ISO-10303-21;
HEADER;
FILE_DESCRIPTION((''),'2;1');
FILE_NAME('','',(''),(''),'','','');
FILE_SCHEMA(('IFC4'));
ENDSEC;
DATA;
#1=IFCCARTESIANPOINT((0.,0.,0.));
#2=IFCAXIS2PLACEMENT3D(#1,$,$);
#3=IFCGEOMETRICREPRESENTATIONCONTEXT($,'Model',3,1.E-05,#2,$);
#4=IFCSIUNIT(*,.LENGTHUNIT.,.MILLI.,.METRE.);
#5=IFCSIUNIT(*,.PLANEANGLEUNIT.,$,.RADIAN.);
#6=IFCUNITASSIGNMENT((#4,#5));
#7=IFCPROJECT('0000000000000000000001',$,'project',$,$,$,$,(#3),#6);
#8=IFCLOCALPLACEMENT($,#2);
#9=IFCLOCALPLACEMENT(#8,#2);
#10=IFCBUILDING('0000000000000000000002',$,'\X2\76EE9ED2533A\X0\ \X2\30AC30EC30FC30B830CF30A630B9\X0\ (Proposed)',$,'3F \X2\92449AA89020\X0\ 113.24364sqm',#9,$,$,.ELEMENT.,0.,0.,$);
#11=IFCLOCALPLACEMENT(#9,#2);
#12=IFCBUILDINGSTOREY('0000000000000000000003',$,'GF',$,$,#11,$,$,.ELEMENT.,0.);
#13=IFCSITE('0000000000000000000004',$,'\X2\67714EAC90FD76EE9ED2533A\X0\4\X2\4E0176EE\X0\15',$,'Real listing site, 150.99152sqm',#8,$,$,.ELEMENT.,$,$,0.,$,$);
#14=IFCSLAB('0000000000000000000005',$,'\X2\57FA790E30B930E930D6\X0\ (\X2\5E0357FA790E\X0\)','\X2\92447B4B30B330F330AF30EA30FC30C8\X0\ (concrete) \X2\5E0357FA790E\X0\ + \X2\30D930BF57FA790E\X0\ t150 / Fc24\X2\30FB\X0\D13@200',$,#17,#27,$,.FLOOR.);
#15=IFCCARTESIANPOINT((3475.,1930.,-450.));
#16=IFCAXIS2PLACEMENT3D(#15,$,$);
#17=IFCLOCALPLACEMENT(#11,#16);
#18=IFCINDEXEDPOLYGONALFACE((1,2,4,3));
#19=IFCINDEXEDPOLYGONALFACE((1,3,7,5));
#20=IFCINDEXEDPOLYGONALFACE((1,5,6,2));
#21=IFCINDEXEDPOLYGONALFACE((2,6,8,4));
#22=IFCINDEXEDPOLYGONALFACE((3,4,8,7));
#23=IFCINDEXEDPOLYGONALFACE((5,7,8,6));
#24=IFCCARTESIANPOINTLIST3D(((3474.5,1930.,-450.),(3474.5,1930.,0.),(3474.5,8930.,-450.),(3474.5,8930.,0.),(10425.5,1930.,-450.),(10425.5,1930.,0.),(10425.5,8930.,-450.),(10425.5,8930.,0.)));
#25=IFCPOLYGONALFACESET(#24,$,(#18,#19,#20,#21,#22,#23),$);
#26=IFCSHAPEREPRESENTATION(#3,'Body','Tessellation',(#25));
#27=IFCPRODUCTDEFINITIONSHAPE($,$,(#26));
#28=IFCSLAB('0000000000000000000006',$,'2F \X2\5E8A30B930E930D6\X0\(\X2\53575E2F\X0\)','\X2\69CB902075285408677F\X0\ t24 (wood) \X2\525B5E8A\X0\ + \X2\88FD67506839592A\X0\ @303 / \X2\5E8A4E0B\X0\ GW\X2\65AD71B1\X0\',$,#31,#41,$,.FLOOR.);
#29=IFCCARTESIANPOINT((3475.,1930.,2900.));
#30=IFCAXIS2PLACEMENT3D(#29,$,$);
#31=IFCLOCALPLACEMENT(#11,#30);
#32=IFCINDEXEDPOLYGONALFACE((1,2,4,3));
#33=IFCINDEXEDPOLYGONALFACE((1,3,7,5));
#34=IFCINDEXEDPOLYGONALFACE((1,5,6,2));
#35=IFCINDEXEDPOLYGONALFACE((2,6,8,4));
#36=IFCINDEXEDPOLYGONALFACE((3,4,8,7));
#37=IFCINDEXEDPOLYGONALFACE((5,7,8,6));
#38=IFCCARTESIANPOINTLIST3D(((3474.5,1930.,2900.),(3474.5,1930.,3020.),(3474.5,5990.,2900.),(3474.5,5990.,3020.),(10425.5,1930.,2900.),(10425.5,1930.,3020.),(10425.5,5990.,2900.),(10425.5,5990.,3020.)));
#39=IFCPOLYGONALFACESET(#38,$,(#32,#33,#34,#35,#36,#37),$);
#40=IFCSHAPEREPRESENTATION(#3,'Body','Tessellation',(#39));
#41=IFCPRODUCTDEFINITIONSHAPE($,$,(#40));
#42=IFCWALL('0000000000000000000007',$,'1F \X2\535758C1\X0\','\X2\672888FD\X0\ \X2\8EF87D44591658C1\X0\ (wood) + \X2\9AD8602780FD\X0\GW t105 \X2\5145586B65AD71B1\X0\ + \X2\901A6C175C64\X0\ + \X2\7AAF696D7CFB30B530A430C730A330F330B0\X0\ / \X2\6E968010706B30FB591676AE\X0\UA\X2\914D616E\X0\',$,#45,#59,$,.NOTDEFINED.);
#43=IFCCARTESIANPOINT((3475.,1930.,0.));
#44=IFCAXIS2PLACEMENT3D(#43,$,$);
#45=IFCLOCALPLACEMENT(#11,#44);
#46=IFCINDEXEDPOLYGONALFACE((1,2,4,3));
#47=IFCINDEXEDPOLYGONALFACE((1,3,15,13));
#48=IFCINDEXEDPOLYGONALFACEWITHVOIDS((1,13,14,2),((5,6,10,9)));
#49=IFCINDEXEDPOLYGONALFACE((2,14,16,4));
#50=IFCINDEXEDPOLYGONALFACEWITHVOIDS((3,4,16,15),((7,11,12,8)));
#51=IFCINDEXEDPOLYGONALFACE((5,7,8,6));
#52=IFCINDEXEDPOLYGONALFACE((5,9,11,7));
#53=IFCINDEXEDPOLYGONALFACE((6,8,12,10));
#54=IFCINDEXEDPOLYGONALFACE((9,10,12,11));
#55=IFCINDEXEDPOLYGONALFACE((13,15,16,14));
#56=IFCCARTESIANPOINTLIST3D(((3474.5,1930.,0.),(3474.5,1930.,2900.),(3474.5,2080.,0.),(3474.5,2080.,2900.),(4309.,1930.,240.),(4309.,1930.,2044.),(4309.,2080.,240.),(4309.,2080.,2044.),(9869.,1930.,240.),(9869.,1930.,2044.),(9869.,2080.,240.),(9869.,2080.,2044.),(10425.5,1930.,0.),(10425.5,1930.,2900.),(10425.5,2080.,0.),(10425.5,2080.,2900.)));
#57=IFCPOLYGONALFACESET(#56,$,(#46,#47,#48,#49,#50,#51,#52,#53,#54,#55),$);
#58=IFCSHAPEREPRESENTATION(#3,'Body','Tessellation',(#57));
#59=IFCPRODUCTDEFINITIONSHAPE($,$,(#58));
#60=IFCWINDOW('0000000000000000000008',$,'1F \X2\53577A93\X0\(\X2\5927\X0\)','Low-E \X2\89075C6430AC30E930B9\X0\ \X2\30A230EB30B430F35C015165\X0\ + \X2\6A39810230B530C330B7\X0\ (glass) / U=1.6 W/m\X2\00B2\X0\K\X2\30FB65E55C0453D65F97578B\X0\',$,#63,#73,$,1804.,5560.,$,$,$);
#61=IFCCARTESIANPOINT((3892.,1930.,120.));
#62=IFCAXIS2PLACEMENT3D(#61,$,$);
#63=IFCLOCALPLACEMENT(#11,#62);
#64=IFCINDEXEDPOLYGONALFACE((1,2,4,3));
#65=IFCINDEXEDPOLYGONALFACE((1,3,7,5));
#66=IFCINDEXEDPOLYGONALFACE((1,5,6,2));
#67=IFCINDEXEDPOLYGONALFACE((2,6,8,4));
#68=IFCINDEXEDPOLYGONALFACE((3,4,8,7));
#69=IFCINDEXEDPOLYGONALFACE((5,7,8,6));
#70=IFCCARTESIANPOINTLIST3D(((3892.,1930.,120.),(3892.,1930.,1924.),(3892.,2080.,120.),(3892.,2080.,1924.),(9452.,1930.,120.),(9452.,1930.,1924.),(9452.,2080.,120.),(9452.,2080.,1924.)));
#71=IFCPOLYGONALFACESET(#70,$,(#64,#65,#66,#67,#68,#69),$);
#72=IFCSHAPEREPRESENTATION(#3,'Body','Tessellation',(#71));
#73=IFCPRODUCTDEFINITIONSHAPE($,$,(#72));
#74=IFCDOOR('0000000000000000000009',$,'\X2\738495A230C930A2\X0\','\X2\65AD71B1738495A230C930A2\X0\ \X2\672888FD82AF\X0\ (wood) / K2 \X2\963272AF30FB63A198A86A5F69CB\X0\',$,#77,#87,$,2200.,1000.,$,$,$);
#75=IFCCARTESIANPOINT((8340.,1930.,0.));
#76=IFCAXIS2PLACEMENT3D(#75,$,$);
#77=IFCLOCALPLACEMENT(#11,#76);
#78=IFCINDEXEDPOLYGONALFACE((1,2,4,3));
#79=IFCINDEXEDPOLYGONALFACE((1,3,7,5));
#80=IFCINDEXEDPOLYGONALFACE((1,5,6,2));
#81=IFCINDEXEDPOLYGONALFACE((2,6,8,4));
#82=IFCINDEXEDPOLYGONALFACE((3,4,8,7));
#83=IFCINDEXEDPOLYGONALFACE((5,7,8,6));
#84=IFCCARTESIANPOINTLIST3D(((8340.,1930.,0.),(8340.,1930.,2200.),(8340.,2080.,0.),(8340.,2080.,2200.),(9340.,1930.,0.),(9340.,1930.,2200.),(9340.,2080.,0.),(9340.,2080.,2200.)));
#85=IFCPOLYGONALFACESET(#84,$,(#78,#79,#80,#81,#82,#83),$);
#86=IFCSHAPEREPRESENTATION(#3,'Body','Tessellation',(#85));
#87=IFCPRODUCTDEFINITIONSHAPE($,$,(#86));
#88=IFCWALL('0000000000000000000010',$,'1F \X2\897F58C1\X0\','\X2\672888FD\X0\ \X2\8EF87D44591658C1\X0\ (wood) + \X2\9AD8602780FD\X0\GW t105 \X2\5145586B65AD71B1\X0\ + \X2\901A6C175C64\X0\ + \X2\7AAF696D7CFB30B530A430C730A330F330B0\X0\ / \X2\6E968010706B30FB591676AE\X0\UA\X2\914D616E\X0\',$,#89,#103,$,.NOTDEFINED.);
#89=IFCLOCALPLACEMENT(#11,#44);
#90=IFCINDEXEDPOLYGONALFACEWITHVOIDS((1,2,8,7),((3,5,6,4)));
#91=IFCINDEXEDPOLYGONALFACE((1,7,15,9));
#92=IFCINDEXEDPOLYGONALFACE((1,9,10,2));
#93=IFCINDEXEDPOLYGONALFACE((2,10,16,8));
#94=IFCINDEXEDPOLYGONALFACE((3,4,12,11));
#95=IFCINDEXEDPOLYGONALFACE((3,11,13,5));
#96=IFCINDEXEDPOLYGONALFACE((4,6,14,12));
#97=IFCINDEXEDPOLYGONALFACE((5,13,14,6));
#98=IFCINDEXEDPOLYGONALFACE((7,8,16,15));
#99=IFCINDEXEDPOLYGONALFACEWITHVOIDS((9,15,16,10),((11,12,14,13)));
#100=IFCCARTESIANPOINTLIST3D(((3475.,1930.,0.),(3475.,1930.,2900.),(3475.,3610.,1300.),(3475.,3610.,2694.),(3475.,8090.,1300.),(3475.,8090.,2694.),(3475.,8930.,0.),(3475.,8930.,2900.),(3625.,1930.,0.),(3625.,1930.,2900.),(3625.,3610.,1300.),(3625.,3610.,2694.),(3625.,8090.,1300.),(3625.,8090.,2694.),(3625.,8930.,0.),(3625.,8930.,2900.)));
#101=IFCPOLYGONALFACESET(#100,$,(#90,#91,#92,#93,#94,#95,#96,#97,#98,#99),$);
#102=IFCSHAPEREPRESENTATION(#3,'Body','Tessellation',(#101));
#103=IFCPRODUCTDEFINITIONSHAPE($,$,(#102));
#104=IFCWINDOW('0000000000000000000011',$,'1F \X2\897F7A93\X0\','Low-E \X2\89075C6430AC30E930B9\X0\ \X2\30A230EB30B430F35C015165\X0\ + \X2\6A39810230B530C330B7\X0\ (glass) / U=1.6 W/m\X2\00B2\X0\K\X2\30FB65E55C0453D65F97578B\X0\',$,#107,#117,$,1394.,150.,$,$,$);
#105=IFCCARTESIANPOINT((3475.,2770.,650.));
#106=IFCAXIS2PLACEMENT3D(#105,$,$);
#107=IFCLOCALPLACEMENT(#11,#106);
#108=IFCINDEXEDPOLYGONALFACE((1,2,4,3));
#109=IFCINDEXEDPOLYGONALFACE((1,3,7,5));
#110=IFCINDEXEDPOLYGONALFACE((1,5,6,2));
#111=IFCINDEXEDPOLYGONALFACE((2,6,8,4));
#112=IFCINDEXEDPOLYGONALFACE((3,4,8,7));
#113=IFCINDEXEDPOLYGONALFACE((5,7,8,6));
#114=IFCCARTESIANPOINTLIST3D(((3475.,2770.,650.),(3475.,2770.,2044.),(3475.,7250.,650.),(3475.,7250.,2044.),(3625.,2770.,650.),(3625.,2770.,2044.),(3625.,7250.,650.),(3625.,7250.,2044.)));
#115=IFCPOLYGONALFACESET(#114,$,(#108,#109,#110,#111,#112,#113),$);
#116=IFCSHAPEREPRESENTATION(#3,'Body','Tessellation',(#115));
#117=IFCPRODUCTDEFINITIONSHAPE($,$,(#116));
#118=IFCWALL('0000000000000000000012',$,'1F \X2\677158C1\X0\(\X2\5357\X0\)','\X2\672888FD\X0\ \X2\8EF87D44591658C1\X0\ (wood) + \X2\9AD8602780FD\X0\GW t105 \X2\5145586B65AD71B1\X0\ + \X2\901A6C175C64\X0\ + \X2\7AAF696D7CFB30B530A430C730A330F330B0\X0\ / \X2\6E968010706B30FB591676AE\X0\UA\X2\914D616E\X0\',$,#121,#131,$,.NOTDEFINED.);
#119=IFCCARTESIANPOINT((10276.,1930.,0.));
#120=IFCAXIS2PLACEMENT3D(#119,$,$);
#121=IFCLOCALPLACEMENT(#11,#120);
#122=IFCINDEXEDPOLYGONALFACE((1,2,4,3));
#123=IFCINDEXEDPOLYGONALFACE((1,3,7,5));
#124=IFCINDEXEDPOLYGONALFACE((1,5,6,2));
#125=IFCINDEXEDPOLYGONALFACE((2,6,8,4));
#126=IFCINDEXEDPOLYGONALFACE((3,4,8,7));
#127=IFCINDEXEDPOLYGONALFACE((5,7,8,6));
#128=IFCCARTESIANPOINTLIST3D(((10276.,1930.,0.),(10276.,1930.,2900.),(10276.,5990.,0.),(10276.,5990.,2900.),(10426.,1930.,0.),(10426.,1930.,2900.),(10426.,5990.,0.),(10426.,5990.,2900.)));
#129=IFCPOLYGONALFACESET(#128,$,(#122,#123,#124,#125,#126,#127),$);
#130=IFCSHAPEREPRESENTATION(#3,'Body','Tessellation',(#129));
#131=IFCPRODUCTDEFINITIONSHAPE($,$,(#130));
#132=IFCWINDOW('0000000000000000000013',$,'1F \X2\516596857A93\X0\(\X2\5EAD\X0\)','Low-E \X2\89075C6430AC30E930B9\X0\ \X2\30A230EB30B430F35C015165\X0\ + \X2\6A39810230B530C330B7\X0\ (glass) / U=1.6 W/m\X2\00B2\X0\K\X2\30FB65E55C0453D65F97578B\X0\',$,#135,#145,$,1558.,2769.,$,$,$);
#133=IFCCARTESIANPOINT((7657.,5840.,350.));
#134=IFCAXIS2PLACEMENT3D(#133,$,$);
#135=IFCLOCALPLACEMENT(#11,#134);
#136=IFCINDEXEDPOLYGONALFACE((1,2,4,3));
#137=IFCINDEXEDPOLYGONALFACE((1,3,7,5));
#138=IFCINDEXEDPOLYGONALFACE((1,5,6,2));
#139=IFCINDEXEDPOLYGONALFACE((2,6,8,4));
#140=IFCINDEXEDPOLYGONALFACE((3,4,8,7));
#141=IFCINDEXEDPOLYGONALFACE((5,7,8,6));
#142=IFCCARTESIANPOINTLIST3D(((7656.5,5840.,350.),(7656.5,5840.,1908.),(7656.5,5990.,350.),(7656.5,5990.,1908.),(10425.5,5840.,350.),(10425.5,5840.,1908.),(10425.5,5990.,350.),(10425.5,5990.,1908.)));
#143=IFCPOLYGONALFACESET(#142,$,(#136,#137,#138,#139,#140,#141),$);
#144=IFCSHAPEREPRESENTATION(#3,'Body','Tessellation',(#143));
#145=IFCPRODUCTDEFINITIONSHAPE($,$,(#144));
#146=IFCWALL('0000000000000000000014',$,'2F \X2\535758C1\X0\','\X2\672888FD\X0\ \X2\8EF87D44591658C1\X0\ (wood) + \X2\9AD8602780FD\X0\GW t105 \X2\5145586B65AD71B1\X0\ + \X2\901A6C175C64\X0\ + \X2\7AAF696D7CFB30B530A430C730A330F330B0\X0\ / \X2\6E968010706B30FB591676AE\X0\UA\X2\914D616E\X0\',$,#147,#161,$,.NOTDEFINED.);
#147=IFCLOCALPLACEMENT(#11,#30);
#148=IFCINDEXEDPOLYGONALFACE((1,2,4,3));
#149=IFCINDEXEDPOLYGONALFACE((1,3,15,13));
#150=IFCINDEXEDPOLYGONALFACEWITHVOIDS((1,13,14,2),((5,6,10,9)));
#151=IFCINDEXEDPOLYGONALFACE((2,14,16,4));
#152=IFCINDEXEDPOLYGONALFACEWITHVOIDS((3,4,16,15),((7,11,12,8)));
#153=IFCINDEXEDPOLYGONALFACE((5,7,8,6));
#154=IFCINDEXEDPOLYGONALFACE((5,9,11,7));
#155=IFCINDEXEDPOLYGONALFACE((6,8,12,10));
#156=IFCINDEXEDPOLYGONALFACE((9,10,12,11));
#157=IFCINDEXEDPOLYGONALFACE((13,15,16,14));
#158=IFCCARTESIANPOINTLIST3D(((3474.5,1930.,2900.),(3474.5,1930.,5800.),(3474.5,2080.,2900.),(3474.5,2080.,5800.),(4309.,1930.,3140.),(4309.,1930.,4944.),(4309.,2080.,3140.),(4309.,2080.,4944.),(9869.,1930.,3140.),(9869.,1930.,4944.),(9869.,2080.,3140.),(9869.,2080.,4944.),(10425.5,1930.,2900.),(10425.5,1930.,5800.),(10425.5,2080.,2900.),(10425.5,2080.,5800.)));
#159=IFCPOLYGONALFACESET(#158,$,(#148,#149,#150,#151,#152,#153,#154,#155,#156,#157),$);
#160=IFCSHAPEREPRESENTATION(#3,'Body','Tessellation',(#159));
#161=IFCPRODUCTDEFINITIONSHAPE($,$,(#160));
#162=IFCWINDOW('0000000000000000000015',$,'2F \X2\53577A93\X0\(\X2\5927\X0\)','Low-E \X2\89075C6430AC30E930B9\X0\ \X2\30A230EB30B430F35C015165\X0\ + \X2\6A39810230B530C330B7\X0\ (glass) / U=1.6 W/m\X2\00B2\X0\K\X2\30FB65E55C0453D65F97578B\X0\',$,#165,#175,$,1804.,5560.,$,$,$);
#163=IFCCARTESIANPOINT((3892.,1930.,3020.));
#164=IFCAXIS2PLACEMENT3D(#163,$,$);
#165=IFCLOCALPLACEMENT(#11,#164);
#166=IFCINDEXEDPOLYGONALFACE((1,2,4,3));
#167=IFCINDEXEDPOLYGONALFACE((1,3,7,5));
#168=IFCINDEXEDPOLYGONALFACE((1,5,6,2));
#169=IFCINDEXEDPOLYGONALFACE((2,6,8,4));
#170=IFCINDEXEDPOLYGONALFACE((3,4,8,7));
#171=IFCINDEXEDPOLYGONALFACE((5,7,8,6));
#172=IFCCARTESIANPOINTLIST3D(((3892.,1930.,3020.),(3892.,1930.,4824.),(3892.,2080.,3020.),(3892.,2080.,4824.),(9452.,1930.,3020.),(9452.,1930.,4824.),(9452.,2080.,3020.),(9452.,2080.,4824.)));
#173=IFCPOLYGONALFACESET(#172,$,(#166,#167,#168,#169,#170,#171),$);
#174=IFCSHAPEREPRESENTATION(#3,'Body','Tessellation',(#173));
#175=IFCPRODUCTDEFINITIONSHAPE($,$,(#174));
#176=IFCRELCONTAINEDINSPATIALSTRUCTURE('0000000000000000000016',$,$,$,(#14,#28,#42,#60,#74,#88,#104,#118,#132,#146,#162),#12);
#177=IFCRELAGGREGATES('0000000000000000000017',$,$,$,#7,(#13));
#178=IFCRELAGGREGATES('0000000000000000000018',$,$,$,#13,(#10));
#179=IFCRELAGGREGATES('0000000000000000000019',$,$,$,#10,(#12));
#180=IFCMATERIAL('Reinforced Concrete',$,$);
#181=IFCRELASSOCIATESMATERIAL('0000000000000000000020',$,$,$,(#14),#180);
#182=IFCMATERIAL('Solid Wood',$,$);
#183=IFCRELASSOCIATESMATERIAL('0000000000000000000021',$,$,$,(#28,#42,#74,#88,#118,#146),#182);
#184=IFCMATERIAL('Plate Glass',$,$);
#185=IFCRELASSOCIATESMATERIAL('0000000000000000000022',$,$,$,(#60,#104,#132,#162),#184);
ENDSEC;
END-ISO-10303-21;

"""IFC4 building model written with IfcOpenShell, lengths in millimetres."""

from ifc_helpers import new_model, si_unit, frame, frame_2d, origin, place, context, project, spatial, rectangle, extrude, material, element, fill, save


model = new_model("IFC4")

# Units and contexts
model_context = context("Model", 3, precision=1e-05, world=origin())
ifc_project = project(units=[si_unit("LENGTHUNIT", "METRE", prefix="MILLI"), si_unit("PLANEANGLEUNIT", "RADIAN")], contexts=[model_context])

# Site, building, storey
site_placement = place(None, origin())
site = spatial("IfcSite", under=ifc_project, at=site_placement, Name="東京都目黒区4丁目15", ObjectType="Real listing site, 150.99152sqm", CompositionType="ELEMENT", RefElevation=0.0)
building_placement = place(site_placement, origin())
building = spatial("IfcBuilding", under=site, at=building_placement, Name="目黒区 ガレージハウス (Proposed)", ObjectType="3F 鉄骨造 113.24364sqm", CompositionType="ELEMENT", ElevationOfRefHeight=0.0, ElevationOfTerrain=0.0)
storey_placement = place(building_placement, origin())
storey = spatial("IfcBuildingStorey", under=building, at=storey_placement, Name="GF", CompositionType="ELEMENT", Elevation=0.0)

# Slabs
ifc_material_1 = material(Name="Reinforced Concrete")
slab_1_placement = place(storey_placement, frame((3475.0, 1930.0, -450.0)))
element("IfcSlab", 1, at=slab_1_placement, inside=storey, material=ifc_material_1, Name="基礎スラブ (布基礎)", Description="鉄筋コンクリート (concrete) 布基礎 + ベタ基礎 t150 / Fc24・D13@200", PredefinedType="FLOOR", context=model_context, shape_type="SweptSolid", body=[
    extrude(rectangle(XDim=6951.0, YDim=7000.0, at=frame_2d((3475.0, 3500.0))), frame((3475.0, 1930.0, -450.0)), (0.0, 0.0, 1.0), 450.0),
])
ifc_material_2 = material(Name="Solid Wood")
slab_2_placement = place(storey_placement, frame((3475.0, 1930.0, 2900.0)))
element("IfcSlab", 2, at=slab_2_placement, inside=storey, material=ifc_material_2, Name="2F 床スラブ(南帯)", Description="構造用合板 t24 (wood) 剛床 + 製材根太 @303 / 床下 GW断熱", PredefinedType="FLOOR", context=model_context, shape_type="SweptSolid", body=[
    extrude(rectangle(XDim=6951.0, YDim=4060.0, at=frame_2d((3475.0, 2030.0))), frame((3475.0, 1930.0, 2900.0)), (0.0, 0.0, 1.0), 120.0),
])

# Wall, openings, window, door
wall_1_placement = place(storey_placement, frame((3475.0, 1930.0, 0.0)))
wall_1 = element("IfcWall", 3, at=wall_1_placement, inside=storey, material=ifc_material_2, Name="1F 南壁", Description="木製 軸組外壁 (wood) + 高性能GW t105 充填断熱 + 通気層 + 窯業系サイディング / 準耐火・外皮UA配慮", PredefinedType="NOTDEFINED", context=model_context, shape_type="SweptSolid", body=[
    extrude(rectangle(XDim=6951.0, YDim=150.0, at=frame_2d((3475.0, 75.0))), frame((3475.0, 1930.0, 0.0)), (0.0, 0.0, 1.0), 2900.0),
])
opening_1_placement = place(storey_placement, frame((3892.0, 1930.0, 120.0)))
opening_1 = element("IfcOpeningElement", 4, at=opening_1_placement, cuts=wall_1, PredefinedType="NOTDEFINED", context=model_context, shape_type="SweptSolid", body=[
    extrude(rectangle(XDim=5560.0, YDim=150.0, at=frame_2d((2780.0, 75.0))), frame((3892.0, 1930.0, 120.0)), (0.0, 0.0, 1.0), 1804.0),
])
opening_2_placement = place(storey_placement, frame((8340.0, 1930.0, 0.0)))
opening_2 = element("IfcOpeningElement", 5, at=opening_2_placement, cuts=wall_1, PredefinedType="NOTDEFINED", context=model_context, shape_type="SweptSolid", body=[
    extrude(rectangle(XDim=1000.0, YDim=150.0, at=frame_2d((500.0, 75.0))), frame((8340.0, 1930.0, 0.0)), (0.0, 0.0, 1.0), 2200.0),
])
ifc_material_3 = material(Name="Plate Glass")
window_1_placement = place(storey_placement, frame((3892.0, 1930.0, 120.0)))
window_1 = element("IfcWindow", 6, at=window_1_placement, inside=storey, material=ifc_material_3, Name="1F 南窓(大)", Description="Low-E 複層ガラス アルゴン封入 + 樹脂サッシ (glass) / U=1.6 W/m²K・日射取得型", OverallHeight=1804.0, OverallWidth=5560.0, context=model_context, shape_type="SweptSolid", body=[
    extrude(rectangle(XDim=5560.0, YDim=150.0, at=frame_2d((2780.0, 75.0))), frame((3892.0, 1930.0, 120.0)), (0.0, 0.0, 1.0), 1804.0),
])
fill(opening_1, window_1)
door_1_placement = place(storey_placement, frame((8340.0, 1930.0, 0.0)))
door_1 = element("IfcDoor", 7, at=door_1_placement, inside=storey, material=ifc_material_2, Name="玄関ドア", Description="断熱玄関ドア 木製芯 (wood) / K2 防犯・採風機構", OverallHeight=2200.0, OverallWidth=1000.0, context=model_context, shape_type="SweptSolid", body=[
    extrude(rectangle(XDim=1000.0, YDim=150.0, at=frame_2d((500.0, 75.0))), frame((8340.0, 1930.0, 0.0)), (0.0, 0.0, 1.0), 2200.0),
])
fill(opening_2, door_1)

# Walls, openings, windows
wall_2_placement = place(storey_placement, frame((3475.0, 1930.0, 0.0)))
wall_2 = element("IfcWall", 8, at=wall_2_placement, inside=storey, material=ifc_material_2, Name="1F 西壁", Description="木製 軸組外壁 (wood) + 高性能GW t105 充填断熱 + 通気層 + 窯業系サイディング / 準耐火・外皮UA配慮", PredefinedType="NOTDEFINED", context=model_context, shape_type="SweptSolid", body=[
    extrude(rectangle(XDim=150.0, YDim=7000.0, at=frame_2d((75.0, 3500.0))), frame((3475.0, 1930.0, 0.0)), (0.0, 0.0, 1.0), 2900.0),
])
opening_3_placement = place(storey_placement, frame((3475.0, 2770.0, 650.0)))
opening_3 = element("IfcOpeningElement", 9, at=opening_3_placement, cuts=wall_2, PredefinedType="NOTDEFINED", context=model_context, shape_type="SweptSolid", body=[
    extrude(rectangle(XDim=150.0, YDim=4480.0, at=frame_2d((75.0, 2240.0))), frame((3475.0, 2770.0, 650.0)), (0.0, 0.0, 1.0), 1394.0),
])
window_2_placement = place(storey_placement, frame((3475.0, 2770.0, 650.0)))
window_2 = element("IfcWindow", 10, at=window_2_placement, inside=storey, material=ifc_material_3, Name="1F 西窓", Description="Low-E 複層ガラス アルゴン封入 + 樹脂サッシ (glass) / U=1.6 W/m²K・日射取得型", OverallHeight=1394.0, OverallWidth=150.0, context=model_context, shape_type="SweptSolid", body=[
    extrude(rectangle(XDim=150.0, YDim=4480.0, at=frame_2d((75.0, 2240.0))), frame((3475.0, 2770.0, 650.0)), (0.0, 0.0, 1.0), 1394.0),
])
fill(opening_3, window_2)
wall_3_placement = place(storey_placement, frame((10276.0, 1930.0, 0.0)))
wall_3 = element("IfcWall", 11, at=wall_3_placement, inside=storey, material=ifc_material_2, Name="1F 東壁(南)", Description="木製 軸組外壁 (wood) + 高性能GW t105 充填断熱 + 通気層 + 窯業系サイディング / 準耐火・外皮UA配慮", PredefinedType="NOTDEFINED", context=model_context, shape_type="SweptSolid", body=[
    extrude(rectangle(XDim=150.0, YDim=4060.0, at=frame_2d((75.0, 2030.0))), frame((10276.0, 1930.0, 0.0)), (0.0, 0.0, 1.0), 2900.0),
])
opening_4_placement = place(storey_placement, frame((7657.0, 5840.0, 350.0)))
opening_4 = element("IfcOpeningElement", 12, at=opening_4_placement, cuts=wall_3, PredefinedType="NOTDEFINED", context=model_context, shape_type="SweptSolid", body=[
    extrude(rectangle(XDim=2769.0, YDim=150.0, at=frame_2d((1384.0, 75.0))), frame((7657.0, 5840.0, 350.0)), (0.0, 0.0, 1.0), 1558.0),
])
window_3_placement = place(storey_placement, frame((7657.0, 5840.0, 350.0)))
window_3 = element("IfcWindow", 13, at=window_3_placement, inside=storey, material=ifc_material_3, Name="1F 入隅窓(庭)", Description="Low-E 複層ガラス アルゴン封入 + 樹脂サッシ (glass) / U=1.6 W/m²K・日射取得型", OverallHeight=1558.0, OverallWidth=2769.0, context=model_context, shape_type="SweptSolid", body=[
    extrude(rectangle(XDim=2769.0, YDim=150.0, at=frame_2d((1384.0, 75.0))), frame((7657.0, 5840.0, 350.0)), (0.0, 0.0, 1.0), 1558.0),
])
fill(opening_4, window_3)

# Wall, opening, window
wall_4_placement = place(storey_placement, frame((3475.0, 1930.0, 2900.0)))
wall_4 = element("IfcWall", 14, at=wall_4_placement, inside=storey, material=ifc_material_2, Name="2F 南壁", Description="木製 軸組外壁 (wood) + 高性能GW t105 充填断熱 + 通気層 + 窯業系サイディング / 準耐火・外皮UA配慮", PredefinedType="NOTDEFINED", context=model_context, shape_type="SweptSolid", body=[
    extrude(rectangle(XDim=6951.0, YDim=150.0, at=frame_2d((3475.0, 75.0))), frame((3475.0, 1930.0, 2900.0)), (0.0, 0.0, 1.0), 2900.0),
])
opening_5_placement = place(storey_placement, frame((3892.0, 1930.0, 3020.0)))
opening_5 = element("IfcOpeningElement", 15, at=opening_5_placement, cuts=wall_4, PredefinedType="NOTDEFINED", context=model_context, shape_type="SweptSolid", body=[
    extrude(rectangle(XDim=5560.0, YDim=150.0, at=frame_2d((2780.0, 75.0))), frame((3892.0, 1930.0, 3020.0)), (0.0, 0.0, 1.0), 1804.0),
])
window_4_placement = place(storey_placement, frame((3892.0, 1930.0, 3020.0)))
window_4 = element("IfcWindow", 16, at=window_4_placement, inside=storey, material=ifc_material_3, Name="2F 南窓(大)", Description="Low-E 複層ガラス アルゴン封入 + 樹脂サッシ (glass) / U=1.6 W/m²K・日射取得型", OverallHeight=1804.0, OverallWidth=5560.0, context=model_context, shape_type="SweptSolid", body=[
    extrude(rectangle(XDim=5560.0, YDim=150.0, at=frame_2d((2780.0, 75.0))), frame((3892.0, 1930.0, 3020.0)), (0.0, 0.0, 1.0), 1804.0),
])
fill(opening_5, window_4)

save(model, "model.ifc")
